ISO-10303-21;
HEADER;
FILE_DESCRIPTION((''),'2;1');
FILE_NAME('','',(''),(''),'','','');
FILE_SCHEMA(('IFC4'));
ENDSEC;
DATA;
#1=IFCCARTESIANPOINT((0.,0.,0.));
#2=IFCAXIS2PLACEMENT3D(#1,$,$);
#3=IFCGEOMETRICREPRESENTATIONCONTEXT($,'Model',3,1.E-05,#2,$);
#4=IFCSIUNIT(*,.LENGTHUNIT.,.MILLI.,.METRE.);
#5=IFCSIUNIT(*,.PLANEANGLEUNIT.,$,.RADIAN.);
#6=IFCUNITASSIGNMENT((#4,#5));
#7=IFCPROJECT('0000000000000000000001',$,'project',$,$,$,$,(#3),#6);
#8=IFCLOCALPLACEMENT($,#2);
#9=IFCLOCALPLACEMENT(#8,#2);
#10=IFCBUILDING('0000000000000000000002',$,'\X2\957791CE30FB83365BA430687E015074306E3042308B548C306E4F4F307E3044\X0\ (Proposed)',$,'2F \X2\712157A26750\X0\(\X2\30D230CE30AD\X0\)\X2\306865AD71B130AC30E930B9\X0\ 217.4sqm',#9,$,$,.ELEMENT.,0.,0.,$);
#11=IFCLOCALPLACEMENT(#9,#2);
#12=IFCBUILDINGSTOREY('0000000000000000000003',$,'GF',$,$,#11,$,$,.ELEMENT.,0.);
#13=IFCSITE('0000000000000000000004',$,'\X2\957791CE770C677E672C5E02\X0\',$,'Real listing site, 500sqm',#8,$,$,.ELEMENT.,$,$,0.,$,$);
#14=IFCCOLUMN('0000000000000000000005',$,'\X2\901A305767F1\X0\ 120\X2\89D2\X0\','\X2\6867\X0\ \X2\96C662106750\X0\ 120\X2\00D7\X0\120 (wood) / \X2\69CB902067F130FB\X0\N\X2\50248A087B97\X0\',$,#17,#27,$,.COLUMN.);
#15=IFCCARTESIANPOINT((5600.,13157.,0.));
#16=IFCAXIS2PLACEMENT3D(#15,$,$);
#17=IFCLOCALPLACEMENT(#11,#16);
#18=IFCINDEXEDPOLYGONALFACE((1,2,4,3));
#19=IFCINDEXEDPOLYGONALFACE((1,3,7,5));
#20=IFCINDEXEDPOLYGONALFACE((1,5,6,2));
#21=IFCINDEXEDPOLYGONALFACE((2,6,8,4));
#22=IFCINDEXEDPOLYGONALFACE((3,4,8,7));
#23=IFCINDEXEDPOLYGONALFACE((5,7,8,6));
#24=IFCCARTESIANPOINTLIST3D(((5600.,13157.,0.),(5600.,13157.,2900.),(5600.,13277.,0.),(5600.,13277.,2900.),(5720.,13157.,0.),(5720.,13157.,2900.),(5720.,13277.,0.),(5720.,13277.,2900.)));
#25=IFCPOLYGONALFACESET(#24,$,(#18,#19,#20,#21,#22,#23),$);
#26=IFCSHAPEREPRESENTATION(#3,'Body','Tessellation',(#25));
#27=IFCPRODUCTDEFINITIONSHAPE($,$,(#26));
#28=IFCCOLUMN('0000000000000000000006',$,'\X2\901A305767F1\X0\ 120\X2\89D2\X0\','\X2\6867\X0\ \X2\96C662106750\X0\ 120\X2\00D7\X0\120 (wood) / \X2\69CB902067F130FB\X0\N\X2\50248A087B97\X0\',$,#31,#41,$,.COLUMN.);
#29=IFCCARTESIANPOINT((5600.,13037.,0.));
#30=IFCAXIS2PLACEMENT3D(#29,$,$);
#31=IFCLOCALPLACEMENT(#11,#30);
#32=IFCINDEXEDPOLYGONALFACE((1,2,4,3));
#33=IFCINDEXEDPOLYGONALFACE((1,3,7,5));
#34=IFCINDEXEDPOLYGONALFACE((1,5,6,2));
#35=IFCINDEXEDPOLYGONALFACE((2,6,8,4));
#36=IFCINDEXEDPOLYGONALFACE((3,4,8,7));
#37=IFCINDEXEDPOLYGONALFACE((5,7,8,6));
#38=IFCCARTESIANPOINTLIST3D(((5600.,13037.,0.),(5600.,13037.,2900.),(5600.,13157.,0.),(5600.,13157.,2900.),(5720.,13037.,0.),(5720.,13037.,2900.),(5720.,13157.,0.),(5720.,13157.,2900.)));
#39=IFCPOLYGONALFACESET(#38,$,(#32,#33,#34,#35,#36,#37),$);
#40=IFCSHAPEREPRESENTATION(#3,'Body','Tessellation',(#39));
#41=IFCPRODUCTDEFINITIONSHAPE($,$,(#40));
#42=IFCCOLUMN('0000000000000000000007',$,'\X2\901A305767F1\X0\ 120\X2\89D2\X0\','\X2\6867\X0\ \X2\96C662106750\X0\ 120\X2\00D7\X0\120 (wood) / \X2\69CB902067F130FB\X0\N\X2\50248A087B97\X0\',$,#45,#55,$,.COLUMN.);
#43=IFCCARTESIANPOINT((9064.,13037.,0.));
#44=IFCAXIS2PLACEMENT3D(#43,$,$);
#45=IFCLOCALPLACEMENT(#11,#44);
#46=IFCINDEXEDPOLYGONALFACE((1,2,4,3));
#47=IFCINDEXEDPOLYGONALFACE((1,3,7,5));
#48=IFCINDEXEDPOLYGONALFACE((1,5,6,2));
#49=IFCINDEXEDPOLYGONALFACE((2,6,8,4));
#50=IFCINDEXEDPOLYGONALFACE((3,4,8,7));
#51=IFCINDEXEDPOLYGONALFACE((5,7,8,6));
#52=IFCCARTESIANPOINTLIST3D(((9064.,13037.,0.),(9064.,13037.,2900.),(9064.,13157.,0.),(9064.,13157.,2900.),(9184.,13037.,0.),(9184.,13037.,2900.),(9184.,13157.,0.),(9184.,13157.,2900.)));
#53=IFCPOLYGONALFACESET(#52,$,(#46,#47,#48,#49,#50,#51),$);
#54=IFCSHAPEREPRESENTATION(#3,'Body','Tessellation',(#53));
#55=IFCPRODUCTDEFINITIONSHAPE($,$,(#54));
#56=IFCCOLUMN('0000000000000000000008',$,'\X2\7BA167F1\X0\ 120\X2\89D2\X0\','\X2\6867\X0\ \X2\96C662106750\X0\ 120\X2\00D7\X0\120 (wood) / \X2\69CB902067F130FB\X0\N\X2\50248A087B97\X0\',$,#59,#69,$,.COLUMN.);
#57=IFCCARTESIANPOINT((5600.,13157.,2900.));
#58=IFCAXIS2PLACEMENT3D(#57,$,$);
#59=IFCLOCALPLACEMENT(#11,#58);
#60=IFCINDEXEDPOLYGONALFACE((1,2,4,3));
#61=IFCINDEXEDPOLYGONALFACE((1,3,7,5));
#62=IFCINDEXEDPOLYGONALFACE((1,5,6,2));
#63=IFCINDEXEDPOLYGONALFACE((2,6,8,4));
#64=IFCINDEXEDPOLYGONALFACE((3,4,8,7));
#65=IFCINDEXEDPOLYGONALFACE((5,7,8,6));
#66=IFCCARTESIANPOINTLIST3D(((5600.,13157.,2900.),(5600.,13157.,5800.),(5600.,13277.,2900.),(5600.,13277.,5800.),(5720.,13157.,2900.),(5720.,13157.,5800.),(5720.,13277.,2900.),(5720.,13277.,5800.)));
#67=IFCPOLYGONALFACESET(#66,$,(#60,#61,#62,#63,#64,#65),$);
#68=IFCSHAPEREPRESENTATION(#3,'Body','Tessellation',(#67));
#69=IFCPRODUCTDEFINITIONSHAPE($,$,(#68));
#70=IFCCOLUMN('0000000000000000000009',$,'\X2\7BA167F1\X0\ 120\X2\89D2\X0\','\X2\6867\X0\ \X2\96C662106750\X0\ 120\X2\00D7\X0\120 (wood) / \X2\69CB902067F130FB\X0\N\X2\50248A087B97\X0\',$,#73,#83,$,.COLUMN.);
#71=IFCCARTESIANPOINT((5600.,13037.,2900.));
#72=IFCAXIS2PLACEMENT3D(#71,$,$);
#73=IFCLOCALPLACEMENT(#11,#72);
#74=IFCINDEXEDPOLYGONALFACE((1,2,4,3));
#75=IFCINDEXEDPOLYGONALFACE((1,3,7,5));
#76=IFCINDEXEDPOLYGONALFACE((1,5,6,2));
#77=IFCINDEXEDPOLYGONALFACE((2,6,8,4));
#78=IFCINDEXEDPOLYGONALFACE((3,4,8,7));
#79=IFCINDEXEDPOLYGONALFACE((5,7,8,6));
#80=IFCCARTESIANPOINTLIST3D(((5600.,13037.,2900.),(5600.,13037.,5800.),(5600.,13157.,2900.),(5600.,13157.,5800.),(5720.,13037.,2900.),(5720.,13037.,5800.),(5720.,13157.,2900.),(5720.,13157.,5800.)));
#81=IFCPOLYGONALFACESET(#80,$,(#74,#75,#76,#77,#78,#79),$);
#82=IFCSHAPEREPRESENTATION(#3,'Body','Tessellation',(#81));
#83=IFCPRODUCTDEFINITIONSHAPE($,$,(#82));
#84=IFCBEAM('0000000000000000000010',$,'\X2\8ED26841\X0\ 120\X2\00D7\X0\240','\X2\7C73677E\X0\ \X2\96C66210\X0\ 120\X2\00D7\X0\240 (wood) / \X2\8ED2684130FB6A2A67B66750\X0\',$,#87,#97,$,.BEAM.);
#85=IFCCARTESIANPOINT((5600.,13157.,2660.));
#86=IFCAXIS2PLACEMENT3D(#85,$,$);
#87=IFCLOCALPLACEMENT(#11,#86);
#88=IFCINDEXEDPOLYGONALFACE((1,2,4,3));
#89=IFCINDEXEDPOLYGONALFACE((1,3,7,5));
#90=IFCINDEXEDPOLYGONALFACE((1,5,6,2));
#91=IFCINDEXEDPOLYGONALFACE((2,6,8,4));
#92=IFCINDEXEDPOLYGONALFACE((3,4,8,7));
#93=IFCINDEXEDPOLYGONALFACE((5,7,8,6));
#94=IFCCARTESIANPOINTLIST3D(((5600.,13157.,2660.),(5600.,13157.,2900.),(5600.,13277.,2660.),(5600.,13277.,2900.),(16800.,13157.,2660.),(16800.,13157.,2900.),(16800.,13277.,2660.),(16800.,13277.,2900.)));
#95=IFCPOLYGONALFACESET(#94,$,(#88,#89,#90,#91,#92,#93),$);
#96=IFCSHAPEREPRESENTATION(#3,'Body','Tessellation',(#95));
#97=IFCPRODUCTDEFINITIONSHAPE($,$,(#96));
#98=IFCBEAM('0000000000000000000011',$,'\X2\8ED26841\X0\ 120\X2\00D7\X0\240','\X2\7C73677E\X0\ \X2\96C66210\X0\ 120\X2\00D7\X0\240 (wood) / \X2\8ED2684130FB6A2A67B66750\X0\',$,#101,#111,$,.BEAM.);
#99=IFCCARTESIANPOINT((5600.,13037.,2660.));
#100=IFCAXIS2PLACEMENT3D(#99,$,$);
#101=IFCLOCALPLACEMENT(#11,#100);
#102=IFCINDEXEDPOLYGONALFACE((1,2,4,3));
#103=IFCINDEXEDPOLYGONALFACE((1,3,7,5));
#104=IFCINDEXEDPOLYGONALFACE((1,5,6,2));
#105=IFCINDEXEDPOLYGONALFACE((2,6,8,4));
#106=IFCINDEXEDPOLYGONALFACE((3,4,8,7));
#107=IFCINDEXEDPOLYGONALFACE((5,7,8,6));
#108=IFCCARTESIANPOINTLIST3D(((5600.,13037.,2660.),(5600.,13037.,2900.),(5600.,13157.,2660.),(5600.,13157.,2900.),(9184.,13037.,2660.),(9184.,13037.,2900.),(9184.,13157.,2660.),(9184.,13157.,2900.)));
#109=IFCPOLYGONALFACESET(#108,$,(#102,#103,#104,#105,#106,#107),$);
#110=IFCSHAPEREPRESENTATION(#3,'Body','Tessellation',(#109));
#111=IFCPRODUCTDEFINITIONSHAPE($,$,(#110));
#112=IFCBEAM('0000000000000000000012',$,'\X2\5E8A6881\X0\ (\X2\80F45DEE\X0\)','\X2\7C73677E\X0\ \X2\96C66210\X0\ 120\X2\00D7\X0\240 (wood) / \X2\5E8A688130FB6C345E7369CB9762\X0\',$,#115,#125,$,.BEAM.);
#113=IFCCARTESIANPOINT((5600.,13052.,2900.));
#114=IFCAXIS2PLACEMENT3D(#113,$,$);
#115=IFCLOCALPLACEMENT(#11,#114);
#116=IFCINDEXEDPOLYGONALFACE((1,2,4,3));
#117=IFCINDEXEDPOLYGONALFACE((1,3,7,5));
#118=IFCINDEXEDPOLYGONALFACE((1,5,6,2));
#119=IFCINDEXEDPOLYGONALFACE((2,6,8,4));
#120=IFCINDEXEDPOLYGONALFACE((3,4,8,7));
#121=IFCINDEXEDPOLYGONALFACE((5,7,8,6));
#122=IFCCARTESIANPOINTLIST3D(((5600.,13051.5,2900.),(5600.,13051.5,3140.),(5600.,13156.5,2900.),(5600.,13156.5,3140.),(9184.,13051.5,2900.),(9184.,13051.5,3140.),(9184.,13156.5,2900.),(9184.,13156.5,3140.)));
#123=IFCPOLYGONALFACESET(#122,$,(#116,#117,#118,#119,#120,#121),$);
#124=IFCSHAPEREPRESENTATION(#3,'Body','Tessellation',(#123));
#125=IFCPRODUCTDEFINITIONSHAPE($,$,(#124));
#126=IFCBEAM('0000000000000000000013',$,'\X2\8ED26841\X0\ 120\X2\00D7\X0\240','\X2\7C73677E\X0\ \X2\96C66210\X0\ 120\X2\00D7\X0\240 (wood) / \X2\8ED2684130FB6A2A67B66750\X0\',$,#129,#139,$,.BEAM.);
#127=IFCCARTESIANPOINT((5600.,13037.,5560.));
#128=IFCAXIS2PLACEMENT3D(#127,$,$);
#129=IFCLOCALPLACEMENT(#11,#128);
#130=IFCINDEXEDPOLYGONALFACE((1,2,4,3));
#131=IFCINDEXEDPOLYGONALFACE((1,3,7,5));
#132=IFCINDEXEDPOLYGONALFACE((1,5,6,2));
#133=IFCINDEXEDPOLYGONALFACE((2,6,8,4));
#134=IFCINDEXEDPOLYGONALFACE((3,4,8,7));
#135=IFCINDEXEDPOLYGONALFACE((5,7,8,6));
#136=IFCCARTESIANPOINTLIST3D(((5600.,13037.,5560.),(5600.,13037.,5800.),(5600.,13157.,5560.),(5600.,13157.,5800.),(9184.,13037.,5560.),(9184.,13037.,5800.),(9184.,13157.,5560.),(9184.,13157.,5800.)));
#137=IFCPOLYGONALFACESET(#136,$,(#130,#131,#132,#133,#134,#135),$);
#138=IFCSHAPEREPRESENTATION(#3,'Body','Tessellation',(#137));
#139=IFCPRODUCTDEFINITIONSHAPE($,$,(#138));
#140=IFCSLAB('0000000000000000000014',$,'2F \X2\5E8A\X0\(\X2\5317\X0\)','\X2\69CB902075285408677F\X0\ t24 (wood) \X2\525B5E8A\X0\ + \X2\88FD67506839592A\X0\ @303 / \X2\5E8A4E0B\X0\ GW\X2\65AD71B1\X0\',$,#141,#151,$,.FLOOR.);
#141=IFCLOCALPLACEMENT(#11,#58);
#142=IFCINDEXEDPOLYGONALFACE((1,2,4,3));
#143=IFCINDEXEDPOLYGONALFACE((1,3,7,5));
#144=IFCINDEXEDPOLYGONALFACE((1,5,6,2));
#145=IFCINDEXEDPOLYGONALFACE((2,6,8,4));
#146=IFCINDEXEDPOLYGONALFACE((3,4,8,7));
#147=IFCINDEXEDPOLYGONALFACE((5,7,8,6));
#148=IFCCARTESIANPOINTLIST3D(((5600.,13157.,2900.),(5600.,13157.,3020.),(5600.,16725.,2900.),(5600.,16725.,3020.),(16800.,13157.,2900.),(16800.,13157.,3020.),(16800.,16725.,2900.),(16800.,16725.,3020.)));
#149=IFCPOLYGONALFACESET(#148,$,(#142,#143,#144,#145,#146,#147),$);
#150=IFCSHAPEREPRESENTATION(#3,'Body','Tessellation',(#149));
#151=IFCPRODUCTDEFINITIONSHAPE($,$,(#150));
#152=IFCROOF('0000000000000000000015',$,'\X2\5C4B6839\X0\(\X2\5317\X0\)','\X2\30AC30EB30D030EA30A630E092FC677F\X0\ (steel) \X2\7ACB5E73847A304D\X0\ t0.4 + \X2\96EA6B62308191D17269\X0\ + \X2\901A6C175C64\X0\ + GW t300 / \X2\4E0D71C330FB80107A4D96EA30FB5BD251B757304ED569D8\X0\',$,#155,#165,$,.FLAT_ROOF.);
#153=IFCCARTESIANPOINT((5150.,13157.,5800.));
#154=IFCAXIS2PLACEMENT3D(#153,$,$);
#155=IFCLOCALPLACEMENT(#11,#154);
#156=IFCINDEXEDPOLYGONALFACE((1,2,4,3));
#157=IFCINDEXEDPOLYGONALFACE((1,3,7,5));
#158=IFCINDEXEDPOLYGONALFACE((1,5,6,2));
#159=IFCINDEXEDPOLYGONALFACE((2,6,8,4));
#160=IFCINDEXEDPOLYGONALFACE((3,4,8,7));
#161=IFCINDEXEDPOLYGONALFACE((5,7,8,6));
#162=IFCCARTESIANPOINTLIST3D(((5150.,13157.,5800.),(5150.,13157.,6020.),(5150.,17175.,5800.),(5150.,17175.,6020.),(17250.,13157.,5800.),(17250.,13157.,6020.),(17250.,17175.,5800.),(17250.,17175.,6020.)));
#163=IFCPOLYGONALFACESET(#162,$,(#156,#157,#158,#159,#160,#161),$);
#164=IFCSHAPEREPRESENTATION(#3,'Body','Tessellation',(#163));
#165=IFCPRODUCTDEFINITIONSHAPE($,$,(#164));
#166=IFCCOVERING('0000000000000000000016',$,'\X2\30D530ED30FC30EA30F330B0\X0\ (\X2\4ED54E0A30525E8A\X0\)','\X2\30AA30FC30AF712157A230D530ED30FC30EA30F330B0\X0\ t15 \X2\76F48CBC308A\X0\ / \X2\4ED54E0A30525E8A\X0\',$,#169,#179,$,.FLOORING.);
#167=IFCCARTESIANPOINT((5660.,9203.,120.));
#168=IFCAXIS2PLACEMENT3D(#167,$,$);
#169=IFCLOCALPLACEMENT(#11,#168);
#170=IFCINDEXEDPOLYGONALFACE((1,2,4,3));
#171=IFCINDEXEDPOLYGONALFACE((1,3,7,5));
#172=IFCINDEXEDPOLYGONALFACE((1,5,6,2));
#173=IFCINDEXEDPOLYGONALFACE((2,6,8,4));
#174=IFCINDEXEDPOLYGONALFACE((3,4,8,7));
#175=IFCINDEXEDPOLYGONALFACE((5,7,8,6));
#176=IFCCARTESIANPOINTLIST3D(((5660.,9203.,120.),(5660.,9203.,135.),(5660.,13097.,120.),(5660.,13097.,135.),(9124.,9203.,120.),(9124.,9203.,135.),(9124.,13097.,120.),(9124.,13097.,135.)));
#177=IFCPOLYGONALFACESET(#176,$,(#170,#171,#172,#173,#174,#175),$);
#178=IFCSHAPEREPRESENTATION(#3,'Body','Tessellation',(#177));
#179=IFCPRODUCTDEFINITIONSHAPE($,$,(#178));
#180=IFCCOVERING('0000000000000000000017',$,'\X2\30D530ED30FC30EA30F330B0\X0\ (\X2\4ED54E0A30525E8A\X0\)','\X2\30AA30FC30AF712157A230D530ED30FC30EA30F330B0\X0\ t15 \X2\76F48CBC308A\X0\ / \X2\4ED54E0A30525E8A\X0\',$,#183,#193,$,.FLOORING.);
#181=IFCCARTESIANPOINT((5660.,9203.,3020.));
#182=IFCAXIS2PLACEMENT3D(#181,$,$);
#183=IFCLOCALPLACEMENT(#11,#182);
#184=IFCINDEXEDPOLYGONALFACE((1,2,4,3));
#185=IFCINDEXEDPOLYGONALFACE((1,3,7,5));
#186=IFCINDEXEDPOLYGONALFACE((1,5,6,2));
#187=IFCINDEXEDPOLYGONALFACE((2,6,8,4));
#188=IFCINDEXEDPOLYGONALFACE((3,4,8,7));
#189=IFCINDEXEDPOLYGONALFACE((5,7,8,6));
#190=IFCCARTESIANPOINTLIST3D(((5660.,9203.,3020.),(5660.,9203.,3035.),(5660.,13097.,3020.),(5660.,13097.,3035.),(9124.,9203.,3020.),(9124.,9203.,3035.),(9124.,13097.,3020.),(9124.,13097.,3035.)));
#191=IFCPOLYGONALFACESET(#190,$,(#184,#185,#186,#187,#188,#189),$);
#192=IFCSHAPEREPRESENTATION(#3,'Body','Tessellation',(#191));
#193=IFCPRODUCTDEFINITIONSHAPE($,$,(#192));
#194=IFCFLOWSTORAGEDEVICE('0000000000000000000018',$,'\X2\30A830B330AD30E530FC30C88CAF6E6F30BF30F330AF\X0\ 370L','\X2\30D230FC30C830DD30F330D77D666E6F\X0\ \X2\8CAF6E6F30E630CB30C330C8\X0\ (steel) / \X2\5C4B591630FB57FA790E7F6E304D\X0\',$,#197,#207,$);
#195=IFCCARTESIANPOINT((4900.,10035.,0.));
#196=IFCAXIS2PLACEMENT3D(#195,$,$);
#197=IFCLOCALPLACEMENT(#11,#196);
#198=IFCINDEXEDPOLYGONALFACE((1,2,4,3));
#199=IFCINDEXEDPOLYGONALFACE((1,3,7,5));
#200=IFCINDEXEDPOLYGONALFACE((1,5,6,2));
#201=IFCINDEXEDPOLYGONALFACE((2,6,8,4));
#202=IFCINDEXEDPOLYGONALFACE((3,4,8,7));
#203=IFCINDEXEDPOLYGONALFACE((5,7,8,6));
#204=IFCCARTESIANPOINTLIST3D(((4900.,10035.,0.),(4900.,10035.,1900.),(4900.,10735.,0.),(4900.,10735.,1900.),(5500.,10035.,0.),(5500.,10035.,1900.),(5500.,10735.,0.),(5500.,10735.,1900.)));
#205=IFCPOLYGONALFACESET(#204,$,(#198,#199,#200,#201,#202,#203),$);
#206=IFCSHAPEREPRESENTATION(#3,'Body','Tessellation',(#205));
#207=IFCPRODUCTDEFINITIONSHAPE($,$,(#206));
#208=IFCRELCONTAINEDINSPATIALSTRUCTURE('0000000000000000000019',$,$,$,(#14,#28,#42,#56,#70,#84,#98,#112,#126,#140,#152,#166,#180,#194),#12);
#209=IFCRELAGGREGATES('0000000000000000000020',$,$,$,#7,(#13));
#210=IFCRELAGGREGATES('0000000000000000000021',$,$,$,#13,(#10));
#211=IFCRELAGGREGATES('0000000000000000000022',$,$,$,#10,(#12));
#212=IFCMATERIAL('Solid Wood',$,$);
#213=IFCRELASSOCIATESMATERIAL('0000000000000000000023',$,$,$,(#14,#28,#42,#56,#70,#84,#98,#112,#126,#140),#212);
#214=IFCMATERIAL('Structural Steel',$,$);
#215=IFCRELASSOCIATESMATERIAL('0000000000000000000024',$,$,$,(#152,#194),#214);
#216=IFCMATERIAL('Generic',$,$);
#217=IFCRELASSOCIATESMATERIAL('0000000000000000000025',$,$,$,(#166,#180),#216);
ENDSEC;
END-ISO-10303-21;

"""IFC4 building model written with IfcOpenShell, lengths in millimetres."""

from ifc_helpers import new_model, si_unit, frame, frame_2d, origin, place, context, project, spatial, rectangle, extrude, material, element, save


model = new_model("IFC4")

# Units and contexts
model_context = context("Model", 3, precision=1e-05, world=origin())
ifc_project = project(units=[si_unit("LENGTHUNIT", "METRE", prefix="MILLI"), si_unit("PLANEANGLEUNIT", "RADIAN")], contexts=[model_context])

# Site, building, storey
site_placement = place(None, origin())
site = spatial("IfcSite", under=ifc_project, at=site_placement, Name="長野県松本市", ObjectType="Real listing site, 500sqm", CompositionType="ELEMENT", RefElevation=0.0)
building_placement = place(site_placement, origin())
building = spatial("IfcBuilding", under=site, at=building_placement, Name="長野・茶室と縁側のある和の住まい (Proposed)", ObjectType="2F 無垢材(ヒノキ)と断熱ガラス 217.4sqm", CompositionType="ELEMENT", ElevationOfRefHeight=0.0, ElevationOfTerrain=0.0)
storey_placement = place(building_placement, origin())
storey = spatial("IfcBuildingStorey", under=building, at=storey_placement, Name="GF", CompositionType="ELEMENT", Elevation=0.0)

# Columns
ifc_material_1 = material(Name="Solid Wood")
column_1_placement = place(storey_placement, frame((5600.0, 13157.0, 0.0)))
element("IfcColumn", 1, at=column_1_placement, inside=storey, material=ifc_material_1, Name="通し柱 120角", Description="桧 集成材 120×120 (wood) / 構造柱・N値計算", PredefinedType="COLUMN", context=model_context, shape_type="SweptSolid", body=[
    extrude(rectangle(XDim=120.0, YDim=120.0, at=frame_2d((60.0, 60.0))), frame((5600.0, 13157.0, 0.0)), (0.0, 0.0, 1.0), 2900.0),
])
column_2_placement = place(storey_placement, frame((5600.0, 13037.0, 0.0)))
element("IfcColumn", 2, at=column_2_placement, inside=storey, material=ifc_material_1, Name="通し柱 120角", Description="桧 集成材 120×120 (wood) / 構造柱・N値計算", PredefinedType="COLUMN", context=model_context, shape_type="SweptSolid", body=[
    extrude(rectangle(XDim=120.0, YDim=120.0, at=frame_2d((60.0, 60.0))), frame((5600.0, 13037.0, 0.0)), (0.0, 0.0, 1.0), 2900.0),
])
column_3_placement = place(storey_placement, frame((9064.0, 13037.0, 0.0)))
element("IfcColumn", 3, at=column_3_placement, inside=storey, material=ifc_material_1, Name="通し柱 120角", Description="桧 集成材 120×120 (wood) / 構造柱・N値計算", PredefinedType="COLUMN", context=model_context, shape_type="SweptSolid", body=[
    extrude(rectangle(XDim=120.0, YDim=120.0, at=frame_2d((60.0, 60.0))), frame((9064.0, 13037.0, 0.0)), (0.0, 0.0, 1.0), 2900.0),
])
column_4_placement = place(storey_placement, frame((5600.0, 13157.0, 2900.0)))
element("IfcColumn", 4, at=column_4_placement, inside=storey, material=ifc_material_1, Name="管柱 120角", Description="桧 集成材 120×120 (wood) / 構造柱・N値計算", PredefinedType="COLUMN", context=model_context, shape_type="SweptSolid", body=[
    extrude(rectangle(XDim=120.0, YDim=120.0, at=frame_2d((60.0, 60.0))), frame((5600.0, 13157.0, 2900.0)), (0.0, 0.0, 1.0), 2900.0),
])
column_5_placement = place(storey_placement, frame((5600.0, 13037.0, 2900.0)))
element("IfcColumn", 5, at=column_5_placement, inside=storey, material=ifc_material_1, Name="管柱 120角", Description="桧 集成材 120×120 (wood) / 構造柱・N値計算", PredefinedType="COLUMN", context=model_context, shape_type="SweptSolid", body=[
    extrude(rectangle(XDim=120.0, YDim=120.0, at=frame_2d((60.0, 60.0))), frame((5600.0, 13037.0, 2900.0)), (0.0, 0.0, 1.0), 2900.0),
])

# Beams
beam_1_placement = place(storey_placement, frame((5600.0, 13157.0, 2660.0)))
element("IfcBeam", 6, at=beam_1_placement, inside=storey, material=ifc_material_1, Name="軒桁 120×240", Description="米松 集成 120×240 (wood) / 軒桁・横架材", PredefinedType="BEAM", context=model_context, shape_type="SweptSolid", body=[
    extrude(rectangle(XDim=11200.0, YDim=120.0, at=frame_2d((5600.0, 60.0))), frame((5600.0, 13157.0, 2660.0)), (0.0, 0.0, 1.0), 240.0),
])
beam_2_placement = place(storey_placement, frame((5600.0, 13037.0, 2660.0)))
element("IfcBeam", 7, at=beam_2_placement, inside=storey, material=ifc_material_1, Name="軒桁 120×240", Description="米松 集成 120×240 (wood) / 軒桁・横架材", PredefinedType="BEAM", context=model_context, shape_type="SweptSolid", body=[
    extrude(rectangle(XDim=3584.0, YDim=120.0, at=frame_2d((1792.0, 60.0))), frame((5600.0, 13037.0, 2660.0)), (0.0, 0.0, 1.0), 240.0),
])
beam_3_placement = place(storey_placement, frame((5600.0, 13052.0, 2900.0)))
element("IfcBeam", 8, at=beam_3_placement, inside=storey, material=ifc_material_1, Name="床梁 (胴差)", Description="米松 集成 120×240 (wood) / 床梁・水平構面", PredefinedType="BEAM", context=model_context, shape_type="SweptSolid", body=[
    extrude(rectangle(XDim=3584.0, YDim=105.0, at=frame_2d((1792.0, 52.0))), frame((5600.0, 13052.0, 2900.0)), (0.0, 0.0, 1.0), 240.0),
])
beam_4_placement = place(storey_placement, frame((5600.0, 13037.0, 5560.0)))
element("IfcBeam", 9, at=beam_4_placement, inside=storey, material=ifc_material_1, Name="軒桁 120×240", Description="米松 集成 120×240 (wood) / 軒桁・横架材", PredefinedType="BEAM", context=model_context, shape_type="SweptSolid", body=[
    extrude(rectangle(XDim=3584.0, YDim=120.0, at=frame_2d((1792.0, 60.0))), frame((5600.0, 13037.0, 5560.0)), (0.0, 0.0, 1.0), 240.0),
])

# Slab
slab_1_placement = place(storey_placement, frame((5600.0, 13157.0, 2900.0)))
element("IfcSlab", 10, at=slab_1_placement, inside=storey, material=ifc_material_1, Name="2F 床(北)", Description="構造用合板 t24 (wood) 剛床 + 製材根太 @303 / 床下 GW断熱", PredefinedType="FLOOR", context=model_context, shape_type="SweptSolid", body=[
    extrude(rectangle(XDim=11200.0, YDim=3568.0, at=frame_2d((5600.0, 1784.0))), frame((5600.0, 13157.0, 2900.0)), (0.0, 0.0, 1.0), 120.0),
])

# Roof
ifc_material_2 = material(Name="Structural Steel")
for number, where, name in (
    (11, (5150.0, 13157.0, 5800.0), "屋根(北)"),
):
    element("IfcRoof", number, at=place(storey_placement, frame(where)), inside=storey, material=ifc_material_2, Name=name, Description="ガルバリウム鋼板 (steel) 立平葺き t0.4 + 雪止め金物 + 通気層 + GW t300 / 不燃・耐積雪・寒冷地仕様", PredefinedType="FLAT_ROOF", context=model_context, shape_type="SweptSolid", body=[
        extrude(rectangle(XDim=12100.0, YDim=4018.0, at=frame_2d((6050.0, 2009.0))), frame((5150.0, 13157.0, 5800.0)), (0.0, 0.0, 1.0), 220.0),
    ])

# Coverings
ifc_material_3 = material(Name="Generic")
covering_1_placement = place(storey_placement, frame((5660.0, 9203.0, 120.0)))
element("IfcCovering", 12, at=covering_1_placement, inside=storey, material=ifc_material_3, Name="フローリング (仕上げ床)", Description="オーク無垢フローリング t15 直貼り / 仕上げ床", PredefinedType="FLOORING", context=model_context, shape_type="SweptSolid", body=[
    extrude(rectangle(XDim=3464.0, YDim=3894.0, at=frame_2d((1732.0, 1947.0))), frame((5660.0, 9203.0, 120.0)), (0.0, 0.0, 1.0), 15.0),
])
covering_2_placement = place(storey_placement, frame((5660.0, 9203.0, 3020.0)))
element("IfcCovering", 13, at=covering_2_placement, inside=storey, material=ifc_material_3, Name="フローリング (仕上げ床)", Description="オーク無垢フローリング t15 直貼り / 仕上げ床", PredefinedType="FLOORING", context=model_context, shape_type="SweptSolid", body=[
    extrude(rectangle(XDim=3464.0, YDim=3894.0, at=frame_2d((1732.0, 1947.0))), frame((5660.0, 9203.0, 3020.0)), (0.0, 0.0, 1.0), 15.0),
])

# Flow storage device
flow_storage_device_placement = place(storey_placement, frame((4900.0, 10035.0, 0.0)))
element("IfcFlowStorageDevice", 14, at=flow_storage_device_placement, inside=storey, material=ifc_material_2, Name="エコキュート貯湯タンク 370L", Description="ヒートポンプ給湯 貯湯ユニット (steel) / 屋外・基礎置き", context=model_context, shape_type="SweptSolid", body=[
    extrude(rectangle(XDim=600.0, YDim=700.0, at=frame_2d((300.0, 350.0))), frame((4900.0, 10035.0, 0.0)), (0.0, 0.0, 1.0), 1900.0),
])

save(model, "model.ifc")
